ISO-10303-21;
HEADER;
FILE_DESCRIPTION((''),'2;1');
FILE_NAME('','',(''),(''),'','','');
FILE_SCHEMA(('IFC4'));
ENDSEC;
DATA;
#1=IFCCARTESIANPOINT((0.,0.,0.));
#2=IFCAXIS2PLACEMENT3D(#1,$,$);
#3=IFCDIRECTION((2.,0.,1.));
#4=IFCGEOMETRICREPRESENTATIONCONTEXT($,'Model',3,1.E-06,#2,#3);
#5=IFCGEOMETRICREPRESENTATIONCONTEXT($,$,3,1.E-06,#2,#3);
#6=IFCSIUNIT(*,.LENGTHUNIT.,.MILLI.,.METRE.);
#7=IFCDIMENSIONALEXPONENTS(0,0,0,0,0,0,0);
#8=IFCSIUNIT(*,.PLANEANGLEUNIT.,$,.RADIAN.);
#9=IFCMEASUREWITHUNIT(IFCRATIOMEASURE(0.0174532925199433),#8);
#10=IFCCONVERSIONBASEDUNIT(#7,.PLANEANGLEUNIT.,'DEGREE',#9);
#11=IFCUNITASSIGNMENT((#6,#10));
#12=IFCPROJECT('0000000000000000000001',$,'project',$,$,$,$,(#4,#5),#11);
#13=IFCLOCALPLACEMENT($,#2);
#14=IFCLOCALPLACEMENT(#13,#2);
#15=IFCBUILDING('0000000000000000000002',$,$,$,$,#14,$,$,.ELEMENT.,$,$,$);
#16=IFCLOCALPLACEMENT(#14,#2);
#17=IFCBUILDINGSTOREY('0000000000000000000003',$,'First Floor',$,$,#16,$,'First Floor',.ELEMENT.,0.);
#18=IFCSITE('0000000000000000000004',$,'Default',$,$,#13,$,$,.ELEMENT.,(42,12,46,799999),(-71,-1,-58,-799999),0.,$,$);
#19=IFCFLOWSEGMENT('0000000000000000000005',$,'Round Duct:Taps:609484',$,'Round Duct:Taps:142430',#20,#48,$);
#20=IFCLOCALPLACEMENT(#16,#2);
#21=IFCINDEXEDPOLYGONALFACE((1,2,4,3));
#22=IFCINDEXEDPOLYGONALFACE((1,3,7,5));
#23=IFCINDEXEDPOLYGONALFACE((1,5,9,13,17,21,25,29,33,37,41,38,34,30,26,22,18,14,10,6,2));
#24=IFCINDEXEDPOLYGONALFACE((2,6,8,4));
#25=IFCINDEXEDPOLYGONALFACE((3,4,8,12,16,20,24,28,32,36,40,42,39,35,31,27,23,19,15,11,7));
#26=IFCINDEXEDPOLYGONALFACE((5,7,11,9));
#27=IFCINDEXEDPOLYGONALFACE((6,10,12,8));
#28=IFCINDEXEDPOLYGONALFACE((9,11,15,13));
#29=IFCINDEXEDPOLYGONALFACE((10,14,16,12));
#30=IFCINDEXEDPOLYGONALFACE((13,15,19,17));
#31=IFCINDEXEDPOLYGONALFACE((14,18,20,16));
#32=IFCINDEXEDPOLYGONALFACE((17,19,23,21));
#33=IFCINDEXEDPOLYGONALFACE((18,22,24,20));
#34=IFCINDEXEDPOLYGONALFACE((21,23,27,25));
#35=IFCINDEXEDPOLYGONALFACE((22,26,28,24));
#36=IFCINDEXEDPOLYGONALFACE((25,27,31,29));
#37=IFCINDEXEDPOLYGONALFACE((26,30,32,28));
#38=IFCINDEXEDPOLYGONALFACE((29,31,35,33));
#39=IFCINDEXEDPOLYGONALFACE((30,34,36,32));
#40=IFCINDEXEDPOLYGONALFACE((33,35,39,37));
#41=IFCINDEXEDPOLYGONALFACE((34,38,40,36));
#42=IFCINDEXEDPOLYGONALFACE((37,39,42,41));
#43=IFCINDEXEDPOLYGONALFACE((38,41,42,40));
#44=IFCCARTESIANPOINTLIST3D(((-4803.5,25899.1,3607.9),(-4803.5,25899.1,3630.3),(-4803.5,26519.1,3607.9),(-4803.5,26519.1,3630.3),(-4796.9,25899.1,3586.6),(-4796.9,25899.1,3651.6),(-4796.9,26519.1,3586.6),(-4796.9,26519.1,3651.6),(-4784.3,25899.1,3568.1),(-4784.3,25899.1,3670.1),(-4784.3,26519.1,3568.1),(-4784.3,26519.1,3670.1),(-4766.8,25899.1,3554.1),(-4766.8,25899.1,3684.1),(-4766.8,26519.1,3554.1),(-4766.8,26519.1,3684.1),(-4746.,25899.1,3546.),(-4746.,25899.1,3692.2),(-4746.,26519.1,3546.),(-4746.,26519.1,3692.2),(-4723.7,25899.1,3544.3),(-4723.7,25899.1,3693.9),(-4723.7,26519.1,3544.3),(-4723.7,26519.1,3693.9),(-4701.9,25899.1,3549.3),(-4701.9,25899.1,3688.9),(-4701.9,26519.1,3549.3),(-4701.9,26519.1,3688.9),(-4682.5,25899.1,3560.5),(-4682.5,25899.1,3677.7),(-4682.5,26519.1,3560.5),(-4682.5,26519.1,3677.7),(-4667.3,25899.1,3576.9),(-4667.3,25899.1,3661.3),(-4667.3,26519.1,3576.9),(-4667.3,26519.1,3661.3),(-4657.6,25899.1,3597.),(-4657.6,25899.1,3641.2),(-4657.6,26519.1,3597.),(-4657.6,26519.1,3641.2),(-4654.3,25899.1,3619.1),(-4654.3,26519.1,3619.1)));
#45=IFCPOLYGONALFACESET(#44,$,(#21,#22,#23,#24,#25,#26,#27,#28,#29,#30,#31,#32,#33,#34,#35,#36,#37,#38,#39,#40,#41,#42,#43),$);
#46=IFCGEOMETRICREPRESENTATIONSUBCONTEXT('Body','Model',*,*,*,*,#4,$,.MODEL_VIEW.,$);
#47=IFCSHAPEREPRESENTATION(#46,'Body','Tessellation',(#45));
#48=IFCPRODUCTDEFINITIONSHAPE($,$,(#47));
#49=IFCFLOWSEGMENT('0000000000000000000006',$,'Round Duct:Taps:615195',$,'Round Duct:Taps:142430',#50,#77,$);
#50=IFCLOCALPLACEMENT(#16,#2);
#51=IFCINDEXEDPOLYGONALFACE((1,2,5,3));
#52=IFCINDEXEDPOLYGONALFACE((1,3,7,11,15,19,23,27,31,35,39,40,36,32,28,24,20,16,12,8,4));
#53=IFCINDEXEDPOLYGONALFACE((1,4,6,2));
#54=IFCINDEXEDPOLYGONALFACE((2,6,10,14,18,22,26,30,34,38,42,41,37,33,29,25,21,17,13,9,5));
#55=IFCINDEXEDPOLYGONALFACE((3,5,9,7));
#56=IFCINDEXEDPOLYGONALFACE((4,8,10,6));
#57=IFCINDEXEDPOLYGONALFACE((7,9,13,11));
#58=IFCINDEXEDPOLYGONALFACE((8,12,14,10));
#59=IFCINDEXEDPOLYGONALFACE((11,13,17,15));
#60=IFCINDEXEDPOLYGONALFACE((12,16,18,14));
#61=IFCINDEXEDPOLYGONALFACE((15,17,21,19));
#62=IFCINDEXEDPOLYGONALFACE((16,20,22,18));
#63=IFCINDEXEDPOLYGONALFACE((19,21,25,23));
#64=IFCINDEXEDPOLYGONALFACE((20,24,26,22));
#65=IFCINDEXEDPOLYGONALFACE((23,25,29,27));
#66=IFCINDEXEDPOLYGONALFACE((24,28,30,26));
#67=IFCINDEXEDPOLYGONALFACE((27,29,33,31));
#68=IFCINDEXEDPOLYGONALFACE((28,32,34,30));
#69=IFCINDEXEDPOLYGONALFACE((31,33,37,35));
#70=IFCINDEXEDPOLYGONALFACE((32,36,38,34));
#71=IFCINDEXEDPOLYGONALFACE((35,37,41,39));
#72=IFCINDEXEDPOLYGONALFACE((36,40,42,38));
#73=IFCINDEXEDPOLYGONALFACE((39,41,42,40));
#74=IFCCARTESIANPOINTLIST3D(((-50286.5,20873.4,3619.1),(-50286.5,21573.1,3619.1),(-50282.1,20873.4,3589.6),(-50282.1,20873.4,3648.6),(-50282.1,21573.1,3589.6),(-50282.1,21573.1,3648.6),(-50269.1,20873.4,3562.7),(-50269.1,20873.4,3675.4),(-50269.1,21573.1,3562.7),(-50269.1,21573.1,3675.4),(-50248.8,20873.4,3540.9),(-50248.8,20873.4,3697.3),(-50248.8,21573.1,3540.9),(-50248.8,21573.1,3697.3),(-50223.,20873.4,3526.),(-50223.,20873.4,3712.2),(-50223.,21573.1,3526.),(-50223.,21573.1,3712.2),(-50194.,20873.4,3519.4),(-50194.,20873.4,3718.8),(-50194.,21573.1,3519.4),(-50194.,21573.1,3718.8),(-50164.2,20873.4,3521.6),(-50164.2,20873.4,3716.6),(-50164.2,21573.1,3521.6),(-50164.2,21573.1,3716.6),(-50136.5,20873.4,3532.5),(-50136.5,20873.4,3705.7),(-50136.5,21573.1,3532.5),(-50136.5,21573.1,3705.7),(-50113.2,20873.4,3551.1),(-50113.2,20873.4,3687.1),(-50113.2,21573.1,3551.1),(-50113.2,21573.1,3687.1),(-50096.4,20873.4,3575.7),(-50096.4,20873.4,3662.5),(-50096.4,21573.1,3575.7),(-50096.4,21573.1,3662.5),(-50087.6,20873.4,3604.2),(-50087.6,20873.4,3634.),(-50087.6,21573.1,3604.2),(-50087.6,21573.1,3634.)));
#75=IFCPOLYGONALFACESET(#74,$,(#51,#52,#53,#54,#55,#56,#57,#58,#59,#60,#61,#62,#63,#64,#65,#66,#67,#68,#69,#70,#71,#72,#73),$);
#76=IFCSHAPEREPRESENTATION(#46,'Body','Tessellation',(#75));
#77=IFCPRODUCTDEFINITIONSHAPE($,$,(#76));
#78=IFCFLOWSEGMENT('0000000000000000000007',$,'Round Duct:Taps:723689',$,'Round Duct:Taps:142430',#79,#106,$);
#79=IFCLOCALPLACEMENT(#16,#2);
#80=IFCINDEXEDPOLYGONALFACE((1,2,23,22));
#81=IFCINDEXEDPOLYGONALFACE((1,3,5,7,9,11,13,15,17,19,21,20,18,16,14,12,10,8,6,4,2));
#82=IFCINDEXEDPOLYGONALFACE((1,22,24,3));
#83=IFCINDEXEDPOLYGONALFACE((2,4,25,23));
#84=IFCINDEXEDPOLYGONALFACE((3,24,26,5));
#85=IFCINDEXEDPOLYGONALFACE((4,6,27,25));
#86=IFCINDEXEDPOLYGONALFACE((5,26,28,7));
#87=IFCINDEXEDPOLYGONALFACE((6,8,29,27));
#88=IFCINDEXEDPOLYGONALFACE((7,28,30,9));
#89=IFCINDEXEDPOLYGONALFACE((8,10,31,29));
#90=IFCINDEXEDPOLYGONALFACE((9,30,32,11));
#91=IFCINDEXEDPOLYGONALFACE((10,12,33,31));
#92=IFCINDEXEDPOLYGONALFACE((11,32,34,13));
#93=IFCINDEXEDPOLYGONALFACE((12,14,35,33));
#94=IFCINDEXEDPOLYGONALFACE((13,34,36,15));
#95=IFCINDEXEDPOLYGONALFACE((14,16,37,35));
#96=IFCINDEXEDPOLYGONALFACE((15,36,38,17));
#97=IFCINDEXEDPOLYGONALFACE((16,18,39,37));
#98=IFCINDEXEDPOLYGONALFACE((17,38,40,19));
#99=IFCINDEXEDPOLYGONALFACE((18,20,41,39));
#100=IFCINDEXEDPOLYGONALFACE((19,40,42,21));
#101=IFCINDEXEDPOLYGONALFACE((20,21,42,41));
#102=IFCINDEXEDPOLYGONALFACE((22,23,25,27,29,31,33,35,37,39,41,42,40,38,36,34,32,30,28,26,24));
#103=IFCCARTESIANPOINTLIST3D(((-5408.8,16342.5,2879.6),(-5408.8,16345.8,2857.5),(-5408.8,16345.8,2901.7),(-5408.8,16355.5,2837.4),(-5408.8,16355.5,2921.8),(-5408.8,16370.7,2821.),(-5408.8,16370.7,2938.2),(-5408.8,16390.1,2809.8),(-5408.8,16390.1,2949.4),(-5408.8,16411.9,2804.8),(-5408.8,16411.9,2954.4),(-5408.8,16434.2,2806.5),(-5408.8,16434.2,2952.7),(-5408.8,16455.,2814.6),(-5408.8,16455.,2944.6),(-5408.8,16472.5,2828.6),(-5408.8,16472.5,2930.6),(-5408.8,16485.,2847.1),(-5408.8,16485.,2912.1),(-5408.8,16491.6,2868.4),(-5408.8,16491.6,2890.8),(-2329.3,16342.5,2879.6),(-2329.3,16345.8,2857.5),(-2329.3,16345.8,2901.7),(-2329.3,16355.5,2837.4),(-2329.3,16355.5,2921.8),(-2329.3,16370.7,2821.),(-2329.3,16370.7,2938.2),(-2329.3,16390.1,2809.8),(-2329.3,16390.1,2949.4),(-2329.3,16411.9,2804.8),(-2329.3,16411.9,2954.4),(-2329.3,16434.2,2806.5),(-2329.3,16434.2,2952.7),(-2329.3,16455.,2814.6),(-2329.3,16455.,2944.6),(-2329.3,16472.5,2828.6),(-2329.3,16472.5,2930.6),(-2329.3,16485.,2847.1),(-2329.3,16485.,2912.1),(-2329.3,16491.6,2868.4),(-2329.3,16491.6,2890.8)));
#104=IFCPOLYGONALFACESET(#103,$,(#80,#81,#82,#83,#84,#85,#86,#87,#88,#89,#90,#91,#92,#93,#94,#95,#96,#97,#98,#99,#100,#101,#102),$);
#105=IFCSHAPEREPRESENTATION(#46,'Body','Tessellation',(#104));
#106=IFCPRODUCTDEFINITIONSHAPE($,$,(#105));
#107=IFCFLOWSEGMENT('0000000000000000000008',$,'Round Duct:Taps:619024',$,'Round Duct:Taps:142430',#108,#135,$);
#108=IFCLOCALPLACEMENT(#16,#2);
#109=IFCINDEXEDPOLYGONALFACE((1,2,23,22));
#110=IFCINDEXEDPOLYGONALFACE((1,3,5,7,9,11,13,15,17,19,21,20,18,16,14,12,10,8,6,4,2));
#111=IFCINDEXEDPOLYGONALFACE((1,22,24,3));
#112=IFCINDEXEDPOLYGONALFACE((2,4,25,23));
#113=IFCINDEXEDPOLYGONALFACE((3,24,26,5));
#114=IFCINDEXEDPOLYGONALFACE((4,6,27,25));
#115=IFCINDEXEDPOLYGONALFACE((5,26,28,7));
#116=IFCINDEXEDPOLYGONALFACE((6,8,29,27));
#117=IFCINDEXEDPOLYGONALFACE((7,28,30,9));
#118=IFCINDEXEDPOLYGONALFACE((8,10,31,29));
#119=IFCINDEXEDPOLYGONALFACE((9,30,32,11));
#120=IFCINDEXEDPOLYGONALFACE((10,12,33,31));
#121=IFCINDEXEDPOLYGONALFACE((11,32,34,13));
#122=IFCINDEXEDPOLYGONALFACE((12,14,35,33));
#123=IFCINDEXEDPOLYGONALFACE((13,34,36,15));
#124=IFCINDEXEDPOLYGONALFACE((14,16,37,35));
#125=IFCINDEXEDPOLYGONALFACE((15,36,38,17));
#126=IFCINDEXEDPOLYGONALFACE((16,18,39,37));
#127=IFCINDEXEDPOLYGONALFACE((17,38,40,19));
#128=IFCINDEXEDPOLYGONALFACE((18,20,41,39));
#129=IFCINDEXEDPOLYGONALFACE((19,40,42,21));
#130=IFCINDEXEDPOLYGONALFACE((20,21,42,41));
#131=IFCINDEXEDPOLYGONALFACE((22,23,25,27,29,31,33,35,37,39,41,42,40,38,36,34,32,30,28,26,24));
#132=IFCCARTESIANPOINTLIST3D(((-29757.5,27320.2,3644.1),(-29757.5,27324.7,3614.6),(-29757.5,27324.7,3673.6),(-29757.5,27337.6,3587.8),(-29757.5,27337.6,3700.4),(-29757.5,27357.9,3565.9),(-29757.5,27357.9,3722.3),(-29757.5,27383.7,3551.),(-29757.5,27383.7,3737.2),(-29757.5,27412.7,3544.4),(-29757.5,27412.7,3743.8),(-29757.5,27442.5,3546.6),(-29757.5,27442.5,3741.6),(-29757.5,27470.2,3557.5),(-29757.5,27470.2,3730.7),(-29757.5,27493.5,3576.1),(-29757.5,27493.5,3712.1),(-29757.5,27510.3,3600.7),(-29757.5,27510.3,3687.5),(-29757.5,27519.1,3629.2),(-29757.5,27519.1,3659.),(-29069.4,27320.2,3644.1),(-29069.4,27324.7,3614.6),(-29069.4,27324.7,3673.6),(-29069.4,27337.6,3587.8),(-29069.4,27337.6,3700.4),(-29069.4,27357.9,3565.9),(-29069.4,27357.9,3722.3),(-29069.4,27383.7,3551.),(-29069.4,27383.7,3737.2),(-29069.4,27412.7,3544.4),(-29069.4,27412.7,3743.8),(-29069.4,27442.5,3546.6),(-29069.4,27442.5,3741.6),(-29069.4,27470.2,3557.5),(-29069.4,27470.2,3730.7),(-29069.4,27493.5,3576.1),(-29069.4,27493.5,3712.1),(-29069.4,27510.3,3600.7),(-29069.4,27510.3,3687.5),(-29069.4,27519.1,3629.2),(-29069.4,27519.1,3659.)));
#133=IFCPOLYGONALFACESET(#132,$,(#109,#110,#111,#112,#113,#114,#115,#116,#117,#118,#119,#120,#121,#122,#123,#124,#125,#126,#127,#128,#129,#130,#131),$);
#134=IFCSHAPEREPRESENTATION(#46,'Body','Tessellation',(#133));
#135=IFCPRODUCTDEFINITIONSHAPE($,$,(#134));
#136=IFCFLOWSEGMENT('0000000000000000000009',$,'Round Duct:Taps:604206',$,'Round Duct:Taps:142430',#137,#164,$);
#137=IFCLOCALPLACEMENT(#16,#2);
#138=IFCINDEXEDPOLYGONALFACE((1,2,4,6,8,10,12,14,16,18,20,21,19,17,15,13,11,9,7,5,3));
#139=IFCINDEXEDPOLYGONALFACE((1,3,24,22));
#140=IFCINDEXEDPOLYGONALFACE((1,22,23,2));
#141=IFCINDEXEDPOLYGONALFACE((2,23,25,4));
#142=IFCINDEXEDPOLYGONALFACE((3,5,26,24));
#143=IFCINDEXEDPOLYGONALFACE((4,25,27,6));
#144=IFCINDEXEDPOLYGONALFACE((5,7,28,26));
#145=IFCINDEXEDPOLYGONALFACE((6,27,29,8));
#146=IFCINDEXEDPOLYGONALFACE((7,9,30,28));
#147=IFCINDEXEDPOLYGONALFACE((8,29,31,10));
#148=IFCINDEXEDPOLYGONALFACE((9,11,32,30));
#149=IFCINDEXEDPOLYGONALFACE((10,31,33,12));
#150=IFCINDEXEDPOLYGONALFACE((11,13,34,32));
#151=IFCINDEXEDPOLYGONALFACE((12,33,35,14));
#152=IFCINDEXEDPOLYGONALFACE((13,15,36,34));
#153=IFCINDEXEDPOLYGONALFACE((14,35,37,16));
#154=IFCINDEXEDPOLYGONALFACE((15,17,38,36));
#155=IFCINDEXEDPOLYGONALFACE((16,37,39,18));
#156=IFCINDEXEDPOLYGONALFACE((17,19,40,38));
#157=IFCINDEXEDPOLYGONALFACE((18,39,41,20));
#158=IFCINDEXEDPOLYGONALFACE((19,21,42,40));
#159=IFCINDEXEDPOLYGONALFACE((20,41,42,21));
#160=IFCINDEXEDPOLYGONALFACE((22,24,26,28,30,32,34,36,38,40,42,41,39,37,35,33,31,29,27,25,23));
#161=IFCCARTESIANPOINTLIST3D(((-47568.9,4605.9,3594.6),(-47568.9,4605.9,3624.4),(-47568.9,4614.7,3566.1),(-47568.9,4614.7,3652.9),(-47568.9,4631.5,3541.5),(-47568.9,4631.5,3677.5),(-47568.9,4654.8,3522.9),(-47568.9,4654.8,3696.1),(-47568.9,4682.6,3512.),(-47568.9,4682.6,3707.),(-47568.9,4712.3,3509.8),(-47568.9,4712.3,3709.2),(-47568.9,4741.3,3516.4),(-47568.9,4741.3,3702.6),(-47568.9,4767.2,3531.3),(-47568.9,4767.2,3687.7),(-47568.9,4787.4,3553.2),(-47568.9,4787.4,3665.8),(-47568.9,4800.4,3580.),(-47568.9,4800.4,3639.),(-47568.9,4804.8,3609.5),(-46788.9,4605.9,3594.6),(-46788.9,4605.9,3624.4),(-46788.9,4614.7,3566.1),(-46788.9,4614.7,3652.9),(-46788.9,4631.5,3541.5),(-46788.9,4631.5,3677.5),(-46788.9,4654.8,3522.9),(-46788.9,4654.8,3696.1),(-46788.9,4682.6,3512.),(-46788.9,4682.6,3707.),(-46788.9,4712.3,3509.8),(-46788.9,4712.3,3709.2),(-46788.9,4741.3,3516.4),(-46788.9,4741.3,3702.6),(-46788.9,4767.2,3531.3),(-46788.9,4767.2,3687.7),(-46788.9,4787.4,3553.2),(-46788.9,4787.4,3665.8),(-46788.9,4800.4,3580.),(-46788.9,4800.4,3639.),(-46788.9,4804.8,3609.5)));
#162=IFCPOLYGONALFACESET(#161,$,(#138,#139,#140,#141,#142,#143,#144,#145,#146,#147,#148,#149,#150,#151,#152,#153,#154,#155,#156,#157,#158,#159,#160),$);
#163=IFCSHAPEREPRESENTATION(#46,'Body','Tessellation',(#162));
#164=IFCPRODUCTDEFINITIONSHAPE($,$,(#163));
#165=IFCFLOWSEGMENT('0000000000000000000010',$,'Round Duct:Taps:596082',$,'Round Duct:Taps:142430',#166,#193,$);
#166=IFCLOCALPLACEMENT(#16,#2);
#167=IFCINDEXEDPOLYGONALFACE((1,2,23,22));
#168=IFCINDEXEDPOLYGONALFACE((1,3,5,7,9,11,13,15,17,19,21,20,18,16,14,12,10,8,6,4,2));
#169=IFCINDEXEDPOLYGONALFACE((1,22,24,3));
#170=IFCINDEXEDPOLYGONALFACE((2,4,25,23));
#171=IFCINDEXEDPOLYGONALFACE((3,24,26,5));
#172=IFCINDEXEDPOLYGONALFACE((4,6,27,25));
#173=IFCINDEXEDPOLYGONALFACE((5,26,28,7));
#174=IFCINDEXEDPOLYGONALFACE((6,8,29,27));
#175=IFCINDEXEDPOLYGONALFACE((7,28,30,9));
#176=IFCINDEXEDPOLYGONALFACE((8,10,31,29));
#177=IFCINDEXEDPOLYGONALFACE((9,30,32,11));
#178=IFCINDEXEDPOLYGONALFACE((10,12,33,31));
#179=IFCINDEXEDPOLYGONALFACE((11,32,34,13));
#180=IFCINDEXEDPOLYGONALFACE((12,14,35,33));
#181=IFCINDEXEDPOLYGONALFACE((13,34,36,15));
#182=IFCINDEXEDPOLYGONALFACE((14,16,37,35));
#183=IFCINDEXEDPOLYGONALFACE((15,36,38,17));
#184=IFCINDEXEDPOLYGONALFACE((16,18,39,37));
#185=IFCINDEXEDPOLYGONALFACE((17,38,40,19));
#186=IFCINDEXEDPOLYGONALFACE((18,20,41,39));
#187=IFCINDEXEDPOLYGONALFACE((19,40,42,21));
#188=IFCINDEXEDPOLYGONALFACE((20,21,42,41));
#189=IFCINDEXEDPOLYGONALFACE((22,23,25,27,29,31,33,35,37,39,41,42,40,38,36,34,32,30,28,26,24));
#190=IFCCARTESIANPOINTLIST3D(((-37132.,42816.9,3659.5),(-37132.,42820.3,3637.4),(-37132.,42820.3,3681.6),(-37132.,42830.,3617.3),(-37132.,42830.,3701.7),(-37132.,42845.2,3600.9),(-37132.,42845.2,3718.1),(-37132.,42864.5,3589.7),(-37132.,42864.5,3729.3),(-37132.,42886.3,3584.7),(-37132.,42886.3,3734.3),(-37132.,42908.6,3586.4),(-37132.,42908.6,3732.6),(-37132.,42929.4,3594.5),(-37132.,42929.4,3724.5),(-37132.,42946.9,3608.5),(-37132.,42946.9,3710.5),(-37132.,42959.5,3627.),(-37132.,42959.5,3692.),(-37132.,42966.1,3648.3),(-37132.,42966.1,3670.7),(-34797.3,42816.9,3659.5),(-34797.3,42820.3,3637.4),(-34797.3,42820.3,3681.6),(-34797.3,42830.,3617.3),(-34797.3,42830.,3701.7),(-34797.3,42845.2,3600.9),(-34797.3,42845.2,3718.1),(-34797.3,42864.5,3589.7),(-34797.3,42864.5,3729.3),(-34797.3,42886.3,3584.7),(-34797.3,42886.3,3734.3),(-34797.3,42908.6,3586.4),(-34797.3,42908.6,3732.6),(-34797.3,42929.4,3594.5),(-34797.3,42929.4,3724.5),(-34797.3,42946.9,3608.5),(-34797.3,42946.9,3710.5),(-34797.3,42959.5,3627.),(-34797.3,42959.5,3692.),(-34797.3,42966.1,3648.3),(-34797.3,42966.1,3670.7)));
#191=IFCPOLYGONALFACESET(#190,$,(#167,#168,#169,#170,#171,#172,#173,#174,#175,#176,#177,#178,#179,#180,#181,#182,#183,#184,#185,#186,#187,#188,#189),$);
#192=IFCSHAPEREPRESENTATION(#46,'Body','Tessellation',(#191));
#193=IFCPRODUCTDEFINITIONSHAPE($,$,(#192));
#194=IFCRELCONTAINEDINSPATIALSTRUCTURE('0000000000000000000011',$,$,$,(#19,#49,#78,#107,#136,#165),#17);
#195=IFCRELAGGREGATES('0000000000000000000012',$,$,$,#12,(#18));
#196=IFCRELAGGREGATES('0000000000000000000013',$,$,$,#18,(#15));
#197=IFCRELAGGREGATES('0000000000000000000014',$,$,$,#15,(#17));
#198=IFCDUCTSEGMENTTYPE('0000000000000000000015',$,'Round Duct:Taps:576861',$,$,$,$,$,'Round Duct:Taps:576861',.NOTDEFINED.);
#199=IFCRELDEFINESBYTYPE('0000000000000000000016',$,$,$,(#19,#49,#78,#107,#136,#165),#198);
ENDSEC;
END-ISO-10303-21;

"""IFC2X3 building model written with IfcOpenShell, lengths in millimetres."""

from ifc_helpers import new_model, entity, si_unit, converted_unit, direction, frame, frame_2d, origin, origin_2d_with_axis, place, context, subcontext, project, spatial, circle, extrude, type_object, element, save


model = new_model("IFC2X3")

# Units and contexts
model_context = context("Model", 3, precision=1e-06, world=origin(), true_north=direction((2.0, 0.0, 1.0)))
context_of_model = context(None, 3, precision=1e-06, world=origin(), true_north=direction((2.0, 0.0, 1.0)))
body_context = subcontext(model_context, "Body", "Model", "MODEL_VIEW")
ifc_project = project(units=[si_unit("LENGTHUNIT", "METRE", prefix="MILLI"), converted_unit("PLANEANGLEUNIT", "DEGREE", entity("IfcRatioMeasure", 0.0174532925199433), si_unit("PLANEANGLEUNIT", "RADIAN"), dimensions=[0, 0, 0, 0, 0, 0, 0])], contexts=[model_context, context_of_model])

# Site, building, storey
site_placement = place(None, origin())
site = spatial("IfcSite", under=ifc_project, at=site_placement, Name="Default", CompositionType="ELEMENT", RefLatitude=(42, 12, 46, 799999), RefLongitude=(-71, -1, -58, -799999), RefElevation=0.0)
building_placement = place(site_placement, origin())
building = spatial("IfcBuilding", under=site, at=building_placement, CompositionType="ELEMENT")
storey_placement = place(building_placement, origin())
storey = spatial("IfcBuildingStorey", under=building, at=storey_placement, Name="First Floor", LongName="First Floor", CompositionType="ELEMENT", Elevation=0.0)

# Flow segments
duct_segment_type_1 = type_object("IfcDuctSegmentType", Name="Round Duct:Taps:576861", ElementType="Round Duct:Taps:576861", PredefinedType="NOTDEFINED")
flow_segment_1_placement = place(storey_placement, origin())
element("IfcFlowSegment", 1, at=flow_segment_1_placement, inside=storey, type_object=duct_segment_type_1, Name="Round Duct:Taps:609484", ObjectType="Round Duct:Taps:142430", context=body_context, shape_type="SweptSolid", body=[
    extrude(circle(Radius=75.0, at=origin_2d_with_axis()), frame((-4729.3, 25899.1, 3619.1), z_axis=(0.0, 1.0, 0.0), x_axis=(1.0, 0.0, 0.0)), (0.0, 0.0, 1.0), 620.0),
])
flow_segment_2_placement = place(storey_placement, origin())
element("IfcFlowSegment", 2, at=flow_segment_2_placement, inside=storey, type_object=duct_segment_type_1, Name="Round Duct:Taps:615195", ObjectType="Round Duct:Taps:142430", context=body_context, shape_type="SweptSolid", body=[
    extrude(circle(Radius=100.0, at=origin_2d_with_axis()), frame((-50186.5, 20873.4, 3619.1), z_axis=(0.0, 1.0, 0.0), x_axis=(-1.0, 0.0, 0.0)), (0.0, 0.0, 1.0), 699.6),
])
flow_segment_3_placement = place(storey_placement, origin())
element("IfcFlowSegment", 3, at=flow_segment_3_placement, inside=storey, type_object=duct_segment_type_1, Name="Round Duct:Taps:723689", ObjectType="Round Duct:Taps:142430", context=body_context, shape_type="SweptSolid", body=[
    extrude(circle(Radius=75.0, at=origin_2d_with_axis()), frame((-5408.8, 16417.5, 2879.6), z_axis=(1.0, 0.0, 0.0), x_axis=(0.0, -1.0, 0.0)), (0.0, 0.0, 1.0), 3079.5),
])
flow_segment_4_placement = place(storey_placement, origin())
element("IfcFlowSegment", 4, at=flow_segment_4_placement, inside=storey, type_object=duct_segment_type_1, Name="Round Duct:Taps:619024", ObjectType="Round Duct:Taps:142430", context=body_context, shape_type="SweptSolid", body=[
    extrude(circle(Radius=100.0, at=origin_2d_with_axis()), frame((-29757.5, 27420.2, 3644.1), z_axis=(1.0, 0.0, 0.0), x_axis=(0.0, -1.0, 0.0)), (0.0, 0.0, 1.0), 688.1),
])
flow_segment_5_placement = place(storey_placement, origin())
element("IfcFlowSegment", 5, at=flow_segment_5_placement, inside=storey, type_object=duct_segment_type_1, Name="Round Duct:Taps:604206", ObjectType="Round Duct:Taps:142430", context=body_context, shape_type="SweptSolid", body=[
    extrude(circle(Radius=100.0, at=frame_2d((0.0, 0.0), x_axis=(1.0, 0.0))), frame((-47568.9, 4704.8, 3609.5), z_axis=(1.0, 0.0, 0.0), x_axis=(0.0, 1.0, 0.0)), (0.0, 0.0, 1.0), 780.0),
])
flow_segment_6_placement = place(storey_placement, origin())
element("IfcFlowSegment", 6, at=flow_segment_6_placement, inside=storey, type_object=duct_segment_type_1, Name="Round Duct:Taps:596082", ObjectType="Round Duct:Taps:142430", context=body_context, shape_type="SweptSolid", body=[
    extrude(circle(Radius=75.0, at=origin_2d_with_axis()), frame((-37132.0, 42891.9, 3659.5), z_axis=(1.0, 0.0, 0.0), x_axis=(0.0, -1.0, 0.0)), (0.0, 0.0, 1.0), 2334.7),
])

save(model, "model.ifc")
